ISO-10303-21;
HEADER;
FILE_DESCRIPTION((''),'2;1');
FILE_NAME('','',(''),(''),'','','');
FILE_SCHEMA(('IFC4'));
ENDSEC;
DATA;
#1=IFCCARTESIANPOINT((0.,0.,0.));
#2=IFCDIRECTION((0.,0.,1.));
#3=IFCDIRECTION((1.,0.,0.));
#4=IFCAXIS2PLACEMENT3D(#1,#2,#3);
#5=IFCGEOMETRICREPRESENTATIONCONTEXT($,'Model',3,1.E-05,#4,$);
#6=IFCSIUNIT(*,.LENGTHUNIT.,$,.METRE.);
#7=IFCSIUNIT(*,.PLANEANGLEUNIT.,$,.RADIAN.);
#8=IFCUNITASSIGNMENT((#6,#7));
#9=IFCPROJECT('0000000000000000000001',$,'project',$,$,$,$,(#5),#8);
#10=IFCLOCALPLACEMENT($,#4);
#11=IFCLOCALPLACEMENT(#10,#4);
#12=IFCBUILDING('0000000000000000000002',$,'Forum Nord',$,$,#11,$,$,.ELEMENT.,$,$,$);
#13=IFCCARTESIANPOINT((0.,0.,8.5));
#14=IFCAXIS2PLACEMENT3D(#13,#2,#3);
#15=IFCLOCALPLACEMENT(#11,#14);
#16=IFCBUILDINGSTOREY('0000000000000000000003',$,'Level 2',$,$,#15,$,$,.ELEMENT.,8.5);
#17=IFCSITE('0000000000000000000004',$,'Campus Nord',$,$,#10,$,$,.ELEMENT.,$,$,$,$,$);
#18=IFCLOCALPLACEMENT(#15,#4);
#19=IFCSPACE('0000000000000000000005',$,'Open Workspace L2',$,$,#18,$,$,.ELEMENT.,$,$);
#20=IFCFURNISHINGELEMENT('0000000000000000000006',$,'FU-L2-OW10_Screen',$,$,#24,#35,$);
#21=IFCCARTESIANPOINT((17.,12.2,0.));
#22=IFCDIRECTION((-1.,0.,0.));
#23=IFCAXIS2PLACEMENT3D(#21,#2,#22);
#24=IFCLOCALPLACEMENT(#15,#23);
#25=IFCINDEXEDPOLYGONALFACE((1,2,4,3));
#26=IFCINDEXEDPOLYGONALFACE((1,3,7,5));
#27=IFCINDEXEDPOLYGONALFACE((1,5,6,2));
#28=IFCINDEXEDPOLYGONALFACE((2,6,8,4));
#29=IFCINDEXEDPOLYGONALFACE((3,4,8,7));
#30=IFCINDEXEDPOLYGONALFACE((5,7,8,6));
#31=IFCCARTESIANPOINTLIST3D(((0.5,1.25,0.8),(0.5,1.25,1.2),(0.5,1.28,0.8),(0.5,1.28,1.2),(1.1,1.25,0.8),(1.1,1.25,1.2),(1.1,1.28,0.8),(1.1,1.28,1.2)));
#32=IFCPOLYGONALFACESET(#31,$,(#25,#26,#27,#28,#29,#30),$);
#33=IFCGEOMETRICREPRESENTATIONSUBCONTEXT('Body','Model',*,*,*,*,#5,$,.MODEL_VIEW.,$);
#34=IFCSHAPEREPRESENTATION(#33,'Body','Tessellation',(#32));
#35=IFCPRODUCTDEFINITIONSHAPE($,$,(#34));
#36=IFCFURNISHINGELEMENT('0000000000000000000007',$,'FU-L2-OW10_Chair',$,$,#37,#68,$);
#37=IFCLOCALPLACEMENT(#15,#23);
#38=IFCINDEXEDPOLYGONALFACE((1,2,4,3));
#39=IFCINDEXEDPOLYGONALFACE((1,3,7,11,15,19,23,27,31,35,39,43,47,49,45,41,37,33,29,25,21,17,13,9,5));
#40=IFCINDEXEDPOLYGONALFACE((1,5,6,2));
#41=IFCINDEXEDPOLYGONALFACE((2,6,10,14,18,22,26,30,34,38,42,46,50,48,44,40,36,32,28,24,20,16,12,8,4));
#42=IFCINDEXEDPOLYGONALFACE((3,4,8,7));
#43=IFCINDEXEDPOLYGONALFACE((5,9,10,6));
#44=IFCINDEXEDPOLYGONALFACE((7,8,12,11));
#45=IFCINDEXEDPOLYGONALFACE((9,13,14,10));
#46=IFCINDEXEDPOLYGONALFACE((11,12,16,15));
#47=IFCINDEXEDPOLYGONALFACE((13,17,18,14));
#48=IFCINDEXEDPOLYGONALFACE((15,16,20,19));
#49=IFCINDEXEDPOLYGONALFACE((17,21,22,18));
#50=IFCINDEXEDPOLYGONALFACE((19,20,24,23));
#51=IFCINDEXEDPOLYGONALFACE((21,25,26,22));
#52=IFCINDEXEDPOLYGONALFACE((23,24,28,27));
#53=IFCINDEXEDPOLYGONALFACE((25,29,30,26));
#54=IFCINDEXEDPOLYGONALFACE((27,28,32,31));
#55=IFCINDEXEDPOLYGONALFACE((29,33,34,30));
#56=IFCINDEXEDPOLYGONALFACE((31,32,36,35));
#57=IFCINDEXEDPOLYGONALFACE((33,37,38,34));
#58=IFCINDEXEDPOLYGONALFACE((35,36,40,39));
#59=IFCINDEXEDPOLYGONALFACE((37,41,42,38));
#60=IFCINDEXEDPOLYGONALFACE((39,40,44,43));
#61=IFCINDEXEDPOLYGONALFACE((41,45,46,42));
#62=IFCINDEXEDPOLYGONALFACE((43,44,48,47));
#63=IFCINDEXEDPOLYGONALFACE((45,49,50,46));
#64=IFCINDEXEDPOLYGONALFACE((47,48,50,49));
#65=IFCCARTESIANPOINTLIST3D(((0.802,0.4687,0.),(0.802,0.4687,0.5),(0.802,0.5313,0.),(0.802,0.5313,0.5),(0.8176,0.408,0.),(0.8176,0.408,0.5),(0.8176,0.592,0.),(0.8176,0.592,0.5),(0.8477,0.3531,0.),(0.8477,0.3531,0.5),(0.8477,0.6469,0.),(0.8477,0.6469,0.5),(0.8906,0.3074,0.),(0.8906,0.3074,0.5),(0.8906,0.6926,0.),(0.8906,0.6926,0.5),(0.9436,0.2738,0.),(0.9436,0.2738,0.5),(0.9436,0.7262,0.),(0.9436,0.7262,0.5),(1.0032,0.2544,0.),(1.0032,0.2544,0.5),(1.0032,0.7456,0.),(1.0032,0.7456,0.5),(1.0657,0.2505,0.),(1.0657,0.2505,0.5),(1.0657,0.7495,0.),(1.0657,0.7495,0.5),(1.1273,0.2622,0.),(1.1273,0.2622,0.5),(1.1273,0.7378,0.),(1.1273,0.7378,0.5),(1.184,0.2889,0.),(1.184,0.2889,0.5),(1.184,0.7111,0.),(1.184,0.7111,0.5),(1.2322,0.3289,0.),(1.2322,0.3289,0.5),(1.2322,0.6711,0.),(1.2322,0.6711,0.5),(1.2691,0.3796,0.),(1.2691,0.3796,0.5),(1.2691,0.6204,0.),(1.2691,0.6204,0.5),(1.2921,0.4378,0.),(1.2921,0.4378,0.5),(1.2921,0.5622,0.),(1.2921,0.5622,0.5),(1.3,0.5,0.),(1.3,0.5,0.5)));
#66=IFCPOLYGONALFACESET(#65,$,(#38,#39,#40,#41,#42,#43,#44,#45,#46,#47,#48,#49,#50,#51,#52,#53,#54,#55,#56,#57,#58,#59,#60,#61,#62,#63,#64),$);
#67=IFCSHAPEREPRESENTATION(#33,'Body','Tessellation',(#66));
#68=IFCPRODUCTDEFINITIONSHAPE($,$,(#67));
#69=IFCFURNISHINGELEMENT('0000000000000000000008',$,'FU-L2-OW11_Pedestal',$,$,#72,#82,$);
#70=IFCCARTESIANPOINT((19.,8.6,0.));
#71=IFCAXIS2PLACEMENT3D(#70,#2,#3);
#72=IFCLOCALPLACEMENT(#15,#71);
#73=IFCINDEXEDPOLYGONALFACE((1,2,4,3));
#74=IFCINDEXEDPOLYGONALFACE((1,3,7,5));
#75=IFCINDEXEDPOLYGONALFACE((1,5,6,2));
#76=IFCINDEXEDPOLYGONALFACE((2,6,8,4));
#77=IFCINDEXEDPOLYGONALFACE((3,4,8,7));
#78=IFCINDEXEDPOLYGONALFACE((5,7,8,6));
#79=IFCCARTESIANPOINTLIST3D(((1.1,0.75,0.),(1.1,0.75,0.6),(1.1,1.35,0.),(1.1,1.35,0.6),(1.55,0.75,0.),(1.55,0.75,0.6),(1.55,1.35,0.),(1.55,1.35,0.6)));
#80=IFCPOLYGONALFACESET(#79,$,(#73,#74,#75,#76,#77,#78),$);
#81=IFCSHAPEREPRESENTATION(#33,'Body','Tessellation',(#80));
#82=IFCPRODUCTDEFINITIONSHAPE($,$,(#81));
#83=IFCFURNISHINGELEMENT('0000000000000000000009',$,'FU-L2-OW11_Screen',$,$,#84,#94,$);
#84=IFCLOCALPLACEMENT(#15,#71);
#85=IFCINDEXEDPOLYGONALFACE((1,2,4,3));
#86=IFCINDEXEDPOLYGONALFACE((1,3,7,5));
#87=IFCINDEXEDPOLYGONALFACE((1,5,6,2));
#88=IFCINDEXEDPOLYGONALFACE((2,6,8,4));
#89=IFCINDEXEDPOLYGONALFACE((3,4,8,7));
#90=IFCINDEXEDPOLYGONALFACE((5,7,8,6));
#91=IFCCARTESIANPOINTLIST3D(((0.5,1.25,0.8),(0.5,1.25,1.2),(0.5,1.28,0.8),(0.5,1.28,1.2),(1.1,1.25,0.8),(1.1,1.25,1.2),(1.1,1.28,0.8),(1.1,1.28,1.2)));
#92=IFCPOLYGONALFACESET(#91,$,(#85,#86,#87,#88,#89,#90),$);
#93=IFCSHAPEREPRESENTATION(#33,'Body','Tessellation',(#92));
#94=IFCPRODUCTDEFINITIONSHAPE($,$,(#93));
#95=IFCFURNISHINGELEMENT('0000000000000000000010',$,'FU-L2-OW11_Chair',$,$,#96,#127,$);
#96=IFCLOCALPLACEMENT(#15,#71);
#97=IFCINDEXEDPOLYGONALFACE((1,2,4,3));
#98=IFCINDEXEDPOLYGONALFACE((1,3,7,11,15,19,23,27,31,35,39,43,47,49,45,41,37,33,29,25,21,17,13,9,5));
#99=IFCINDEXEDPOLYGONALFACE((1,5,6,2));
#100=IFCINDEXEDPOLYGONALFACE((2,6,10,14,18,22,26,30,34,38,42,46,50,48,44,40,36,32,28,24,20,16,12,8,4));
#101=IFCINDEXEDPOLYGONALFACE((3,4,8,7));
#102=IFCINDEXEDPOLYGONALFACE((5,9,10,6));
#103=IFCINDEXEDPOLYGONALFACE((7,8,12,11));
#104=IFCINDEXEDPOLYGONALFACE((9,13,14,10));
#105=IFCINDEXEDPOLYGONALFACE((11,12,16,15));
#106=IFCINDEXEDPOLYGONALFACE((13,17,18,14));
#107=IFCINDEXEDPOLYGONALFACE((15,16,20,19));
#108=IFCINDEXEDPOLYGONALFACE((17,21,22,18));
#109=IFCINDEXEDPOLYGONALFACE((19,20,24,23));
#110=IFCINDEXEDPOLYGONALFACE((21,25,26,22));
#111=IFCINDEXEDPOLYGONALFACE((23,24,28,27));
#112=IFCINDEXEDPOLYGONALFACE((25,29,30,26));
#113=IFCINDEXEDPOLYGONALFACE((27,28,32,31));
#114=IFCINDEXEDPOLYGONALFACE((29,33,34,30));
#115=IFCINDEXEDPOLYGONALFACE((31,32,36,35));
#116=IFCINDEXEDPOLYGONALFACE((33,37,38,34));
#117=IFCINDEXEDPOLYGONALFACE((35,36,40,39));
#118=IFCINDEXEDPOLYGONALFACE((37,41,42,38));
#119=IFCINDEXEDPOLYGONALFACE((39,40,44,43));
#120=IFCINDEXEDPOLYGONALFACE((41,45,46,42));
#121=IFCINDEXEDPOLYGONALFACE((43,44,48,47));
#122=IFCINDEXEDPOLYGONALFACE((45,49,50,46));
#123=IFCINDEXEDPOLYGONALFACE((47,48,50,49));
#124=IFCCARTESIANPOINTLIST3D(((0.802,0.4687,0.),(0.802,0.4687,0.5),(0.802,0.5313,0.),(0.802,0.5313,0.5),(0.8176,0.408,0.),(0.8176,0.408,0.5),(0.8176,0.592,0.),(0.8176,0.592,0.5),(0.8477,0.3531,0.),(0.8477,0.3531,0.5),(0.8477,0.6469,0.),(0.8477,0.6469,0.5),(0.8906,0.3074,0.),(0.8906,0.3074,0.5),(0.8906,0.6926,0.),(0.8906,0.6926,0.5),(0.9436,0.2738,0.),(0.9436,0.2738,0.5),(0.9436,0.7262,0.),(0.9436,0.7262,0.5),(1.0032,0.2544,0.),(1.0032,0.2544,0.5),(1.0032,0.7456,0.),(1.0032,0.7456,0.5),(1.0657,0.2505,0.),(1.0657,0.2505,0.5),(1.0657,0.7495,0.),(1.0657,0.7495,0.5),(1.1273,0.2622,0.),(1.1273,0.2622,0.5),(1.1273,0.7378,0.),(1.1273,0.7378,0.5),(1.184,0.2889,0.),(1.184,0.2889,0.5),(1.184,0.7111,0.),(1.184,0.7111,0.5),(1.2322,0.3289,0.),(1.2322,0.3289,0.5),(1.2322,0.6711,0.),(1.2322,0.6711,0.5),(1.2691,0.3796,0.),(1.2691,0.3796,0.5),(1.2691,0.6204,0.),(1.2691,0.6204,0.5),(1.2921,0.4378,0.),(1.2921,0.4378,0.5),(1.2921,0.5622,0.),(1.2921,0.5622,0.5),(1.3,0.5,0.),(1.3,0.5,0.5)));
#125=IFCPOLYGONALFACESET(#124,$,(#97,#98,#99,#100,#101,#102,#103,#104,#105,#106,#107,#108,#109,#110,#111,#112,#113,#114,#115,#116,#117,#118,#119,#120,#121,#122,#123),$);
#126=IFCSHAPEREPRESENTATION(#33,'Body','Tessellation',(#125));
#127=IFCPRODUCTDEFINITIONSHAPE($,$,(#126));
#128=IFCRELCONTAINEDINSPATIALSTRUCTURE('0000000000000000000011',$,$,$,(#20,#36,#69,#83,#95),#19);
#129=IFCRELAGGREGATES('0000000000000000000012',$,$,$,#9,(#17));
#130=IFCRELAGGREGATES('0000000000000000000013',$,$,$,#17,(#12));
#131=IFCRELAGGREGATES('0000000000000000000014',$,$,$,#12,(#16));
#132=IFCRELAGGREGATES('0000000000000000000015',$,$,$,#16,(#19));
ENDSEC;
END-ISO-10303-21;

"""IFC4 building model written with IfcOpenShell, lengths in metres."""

from ifc_helpers import new_model, si_unit, frame, frame_2d, origin_with_axes, place, context, subcontext, project, spatial, rectangle, circle, extrude, element, save


model = new_model("IFC4")

# Units and contexts
model_context = context("Model", 3, precision=1e-05, world=origin_with_axes())
body_context = subcontext(model_context, "Body", "Model", "MODEL_VIEW")
ifc_project = project(units=[si_unit("LENGTHUNIT", "METRE"), si_unit("PLANEANGLEUNIT", "RADIAN")], contexts=[model_context])

# Site, building, storey, space
site_placement = place(None, origin_with_axes())
site = spatial("IfcSite", under=ifc_project, at=site_placement, Name="Campus Nord", CompositionType="ELEMENT")
building_placement = place(site_placement, origin_with_axes())
building = spatial("IfcBuilding", under=site, at=building_placement, Name="Forum Nord", CompositionType="ELEMENT")
storey_placement = place(building_placement, frame((0.0, 0.0, 8.5), z_axis=(0.0, 0.0, 1.0), x_axis=(1.0, 0.0, 0.0)))
storey = spatial("IfcBuildingStorey", under=building, at=storey_placement, Name="Level 2", CompositionType="ELEMENT", Elevation=8.5)
space_placement = place(storey_placement, origin_with_axes())
space = spatial("IfcSpace", under=storey, at=space_placement, Name="Open Workspace L2", CompositionType="ELEMENT")

# Furnishing elements
furnishing_1_placement = place(storey_placement, frame((17.0, 12.2, 0.0), z_axis=(0.0, 0.0, 1.0), x_axis=(-1.0, 0.0, 0.0)))
element("IfcFurnishingElement", 1, at=furnishing_1_placement, inside=space, Name="FU-L2-OW10_Screen", context=body_context, shape_type="SweptSolid", body=[
    extrude(rectangle(XDim=0.6, YDim=0.03, at=frame_2d((0.8, 1.265), x_axis=(1.0, 0.0))), frame((0.0, 0.0, 0.8), z_axis=(0.0, 0.0, 1.0), x_axis=(1.0, 0.0, 0.0)), (0.0, 0.0, 1.0), 0.4),
])
furnishing_2_placement = place(storey_placement, frame((17.0, 12.2, 0.0), z_axis=(0.0, 0.0, 1.0), x_axis=(-1.0, 0.0, 0.0)))
element("IfcFurnishingElement", 2, at=furnishing_2_placement, inside=space, Name="FU-L2-OW10_Chair", context=body_context, shape_type="SweptSolid", body=[
    extrude(circle(Radius=0.25, at=frame_2d((1.05, 0.5), x_axis=(1.0, 0.0))), origin_with_axes(), (0.0, 0.0, 1.0), 0.5),
])
furnishing_3_placement = place(storey_placement, frame((19.0, 8.6, 0.0), z_axis=(0.0, 0.0, 1.0), x_axis=(1.0, 0.0, 0.0)))
element("IfcFurnishingElement", 3, at=furnishing_3_placement, inside=space, Name="FU-L2-OW11_Pedestal", context=body_context, shape_type="SweptSolid", body=[
    extrude(rectangle(XDim=0.45, YDim=0.6, at=frame_2d((1.325, 1.05), x_axis=(1.0, 0.0))), origin_with_axes(), (0.0, 0.0, 1.0), 0.6),
])
furnishing_4_placement = place(storey_placement, frame((19.0, 8.6, 0.0), z_axis=(0.0, 0.0, 1.0), x_axis=(1.0, 0.0, 0.0)))
element("IfcFurnishingElement", 4, at=furnishing_4_placement, inside=space, Name="FU-L2-OW11_Screen", context=body_context, shape_type="SweptSolid", body=[
    extrude(rectangle(XDim=0.6, YDim=0.03, at=frame_2d((0.8, 1.265), x_axis=(1.0, 0.0))), frame((0.0, 0.0, 0.8), z_axis=(0.0, 0.0, 1.0), x_axis=(1.0, 0.0, 0.0)), (0.0, 0.0, 1.0), 0.4),
])
furnishing_5_placement = place(storey_placement, frame((19.0, 8.6, 0.0), z_axis=(0.0, 0.0, 1.0), x_axis=(1.0, 0.0, 0.0)))
element("IfcFurnishingElement", 5, at=furnishing_5_placement, inside=space, Name="FU-L2-OW11_Chair", context=body_context, shape_type="SweptSolid", body=[
    extrude(circle(Radius=0.25, at=frame_2d((1.05, 0.5), x_axis=(1.0, 0.0))), origin_with_axes(), (0.0, 0.0, 1.0), 0.5),
])

save(model, "model.ifc")
